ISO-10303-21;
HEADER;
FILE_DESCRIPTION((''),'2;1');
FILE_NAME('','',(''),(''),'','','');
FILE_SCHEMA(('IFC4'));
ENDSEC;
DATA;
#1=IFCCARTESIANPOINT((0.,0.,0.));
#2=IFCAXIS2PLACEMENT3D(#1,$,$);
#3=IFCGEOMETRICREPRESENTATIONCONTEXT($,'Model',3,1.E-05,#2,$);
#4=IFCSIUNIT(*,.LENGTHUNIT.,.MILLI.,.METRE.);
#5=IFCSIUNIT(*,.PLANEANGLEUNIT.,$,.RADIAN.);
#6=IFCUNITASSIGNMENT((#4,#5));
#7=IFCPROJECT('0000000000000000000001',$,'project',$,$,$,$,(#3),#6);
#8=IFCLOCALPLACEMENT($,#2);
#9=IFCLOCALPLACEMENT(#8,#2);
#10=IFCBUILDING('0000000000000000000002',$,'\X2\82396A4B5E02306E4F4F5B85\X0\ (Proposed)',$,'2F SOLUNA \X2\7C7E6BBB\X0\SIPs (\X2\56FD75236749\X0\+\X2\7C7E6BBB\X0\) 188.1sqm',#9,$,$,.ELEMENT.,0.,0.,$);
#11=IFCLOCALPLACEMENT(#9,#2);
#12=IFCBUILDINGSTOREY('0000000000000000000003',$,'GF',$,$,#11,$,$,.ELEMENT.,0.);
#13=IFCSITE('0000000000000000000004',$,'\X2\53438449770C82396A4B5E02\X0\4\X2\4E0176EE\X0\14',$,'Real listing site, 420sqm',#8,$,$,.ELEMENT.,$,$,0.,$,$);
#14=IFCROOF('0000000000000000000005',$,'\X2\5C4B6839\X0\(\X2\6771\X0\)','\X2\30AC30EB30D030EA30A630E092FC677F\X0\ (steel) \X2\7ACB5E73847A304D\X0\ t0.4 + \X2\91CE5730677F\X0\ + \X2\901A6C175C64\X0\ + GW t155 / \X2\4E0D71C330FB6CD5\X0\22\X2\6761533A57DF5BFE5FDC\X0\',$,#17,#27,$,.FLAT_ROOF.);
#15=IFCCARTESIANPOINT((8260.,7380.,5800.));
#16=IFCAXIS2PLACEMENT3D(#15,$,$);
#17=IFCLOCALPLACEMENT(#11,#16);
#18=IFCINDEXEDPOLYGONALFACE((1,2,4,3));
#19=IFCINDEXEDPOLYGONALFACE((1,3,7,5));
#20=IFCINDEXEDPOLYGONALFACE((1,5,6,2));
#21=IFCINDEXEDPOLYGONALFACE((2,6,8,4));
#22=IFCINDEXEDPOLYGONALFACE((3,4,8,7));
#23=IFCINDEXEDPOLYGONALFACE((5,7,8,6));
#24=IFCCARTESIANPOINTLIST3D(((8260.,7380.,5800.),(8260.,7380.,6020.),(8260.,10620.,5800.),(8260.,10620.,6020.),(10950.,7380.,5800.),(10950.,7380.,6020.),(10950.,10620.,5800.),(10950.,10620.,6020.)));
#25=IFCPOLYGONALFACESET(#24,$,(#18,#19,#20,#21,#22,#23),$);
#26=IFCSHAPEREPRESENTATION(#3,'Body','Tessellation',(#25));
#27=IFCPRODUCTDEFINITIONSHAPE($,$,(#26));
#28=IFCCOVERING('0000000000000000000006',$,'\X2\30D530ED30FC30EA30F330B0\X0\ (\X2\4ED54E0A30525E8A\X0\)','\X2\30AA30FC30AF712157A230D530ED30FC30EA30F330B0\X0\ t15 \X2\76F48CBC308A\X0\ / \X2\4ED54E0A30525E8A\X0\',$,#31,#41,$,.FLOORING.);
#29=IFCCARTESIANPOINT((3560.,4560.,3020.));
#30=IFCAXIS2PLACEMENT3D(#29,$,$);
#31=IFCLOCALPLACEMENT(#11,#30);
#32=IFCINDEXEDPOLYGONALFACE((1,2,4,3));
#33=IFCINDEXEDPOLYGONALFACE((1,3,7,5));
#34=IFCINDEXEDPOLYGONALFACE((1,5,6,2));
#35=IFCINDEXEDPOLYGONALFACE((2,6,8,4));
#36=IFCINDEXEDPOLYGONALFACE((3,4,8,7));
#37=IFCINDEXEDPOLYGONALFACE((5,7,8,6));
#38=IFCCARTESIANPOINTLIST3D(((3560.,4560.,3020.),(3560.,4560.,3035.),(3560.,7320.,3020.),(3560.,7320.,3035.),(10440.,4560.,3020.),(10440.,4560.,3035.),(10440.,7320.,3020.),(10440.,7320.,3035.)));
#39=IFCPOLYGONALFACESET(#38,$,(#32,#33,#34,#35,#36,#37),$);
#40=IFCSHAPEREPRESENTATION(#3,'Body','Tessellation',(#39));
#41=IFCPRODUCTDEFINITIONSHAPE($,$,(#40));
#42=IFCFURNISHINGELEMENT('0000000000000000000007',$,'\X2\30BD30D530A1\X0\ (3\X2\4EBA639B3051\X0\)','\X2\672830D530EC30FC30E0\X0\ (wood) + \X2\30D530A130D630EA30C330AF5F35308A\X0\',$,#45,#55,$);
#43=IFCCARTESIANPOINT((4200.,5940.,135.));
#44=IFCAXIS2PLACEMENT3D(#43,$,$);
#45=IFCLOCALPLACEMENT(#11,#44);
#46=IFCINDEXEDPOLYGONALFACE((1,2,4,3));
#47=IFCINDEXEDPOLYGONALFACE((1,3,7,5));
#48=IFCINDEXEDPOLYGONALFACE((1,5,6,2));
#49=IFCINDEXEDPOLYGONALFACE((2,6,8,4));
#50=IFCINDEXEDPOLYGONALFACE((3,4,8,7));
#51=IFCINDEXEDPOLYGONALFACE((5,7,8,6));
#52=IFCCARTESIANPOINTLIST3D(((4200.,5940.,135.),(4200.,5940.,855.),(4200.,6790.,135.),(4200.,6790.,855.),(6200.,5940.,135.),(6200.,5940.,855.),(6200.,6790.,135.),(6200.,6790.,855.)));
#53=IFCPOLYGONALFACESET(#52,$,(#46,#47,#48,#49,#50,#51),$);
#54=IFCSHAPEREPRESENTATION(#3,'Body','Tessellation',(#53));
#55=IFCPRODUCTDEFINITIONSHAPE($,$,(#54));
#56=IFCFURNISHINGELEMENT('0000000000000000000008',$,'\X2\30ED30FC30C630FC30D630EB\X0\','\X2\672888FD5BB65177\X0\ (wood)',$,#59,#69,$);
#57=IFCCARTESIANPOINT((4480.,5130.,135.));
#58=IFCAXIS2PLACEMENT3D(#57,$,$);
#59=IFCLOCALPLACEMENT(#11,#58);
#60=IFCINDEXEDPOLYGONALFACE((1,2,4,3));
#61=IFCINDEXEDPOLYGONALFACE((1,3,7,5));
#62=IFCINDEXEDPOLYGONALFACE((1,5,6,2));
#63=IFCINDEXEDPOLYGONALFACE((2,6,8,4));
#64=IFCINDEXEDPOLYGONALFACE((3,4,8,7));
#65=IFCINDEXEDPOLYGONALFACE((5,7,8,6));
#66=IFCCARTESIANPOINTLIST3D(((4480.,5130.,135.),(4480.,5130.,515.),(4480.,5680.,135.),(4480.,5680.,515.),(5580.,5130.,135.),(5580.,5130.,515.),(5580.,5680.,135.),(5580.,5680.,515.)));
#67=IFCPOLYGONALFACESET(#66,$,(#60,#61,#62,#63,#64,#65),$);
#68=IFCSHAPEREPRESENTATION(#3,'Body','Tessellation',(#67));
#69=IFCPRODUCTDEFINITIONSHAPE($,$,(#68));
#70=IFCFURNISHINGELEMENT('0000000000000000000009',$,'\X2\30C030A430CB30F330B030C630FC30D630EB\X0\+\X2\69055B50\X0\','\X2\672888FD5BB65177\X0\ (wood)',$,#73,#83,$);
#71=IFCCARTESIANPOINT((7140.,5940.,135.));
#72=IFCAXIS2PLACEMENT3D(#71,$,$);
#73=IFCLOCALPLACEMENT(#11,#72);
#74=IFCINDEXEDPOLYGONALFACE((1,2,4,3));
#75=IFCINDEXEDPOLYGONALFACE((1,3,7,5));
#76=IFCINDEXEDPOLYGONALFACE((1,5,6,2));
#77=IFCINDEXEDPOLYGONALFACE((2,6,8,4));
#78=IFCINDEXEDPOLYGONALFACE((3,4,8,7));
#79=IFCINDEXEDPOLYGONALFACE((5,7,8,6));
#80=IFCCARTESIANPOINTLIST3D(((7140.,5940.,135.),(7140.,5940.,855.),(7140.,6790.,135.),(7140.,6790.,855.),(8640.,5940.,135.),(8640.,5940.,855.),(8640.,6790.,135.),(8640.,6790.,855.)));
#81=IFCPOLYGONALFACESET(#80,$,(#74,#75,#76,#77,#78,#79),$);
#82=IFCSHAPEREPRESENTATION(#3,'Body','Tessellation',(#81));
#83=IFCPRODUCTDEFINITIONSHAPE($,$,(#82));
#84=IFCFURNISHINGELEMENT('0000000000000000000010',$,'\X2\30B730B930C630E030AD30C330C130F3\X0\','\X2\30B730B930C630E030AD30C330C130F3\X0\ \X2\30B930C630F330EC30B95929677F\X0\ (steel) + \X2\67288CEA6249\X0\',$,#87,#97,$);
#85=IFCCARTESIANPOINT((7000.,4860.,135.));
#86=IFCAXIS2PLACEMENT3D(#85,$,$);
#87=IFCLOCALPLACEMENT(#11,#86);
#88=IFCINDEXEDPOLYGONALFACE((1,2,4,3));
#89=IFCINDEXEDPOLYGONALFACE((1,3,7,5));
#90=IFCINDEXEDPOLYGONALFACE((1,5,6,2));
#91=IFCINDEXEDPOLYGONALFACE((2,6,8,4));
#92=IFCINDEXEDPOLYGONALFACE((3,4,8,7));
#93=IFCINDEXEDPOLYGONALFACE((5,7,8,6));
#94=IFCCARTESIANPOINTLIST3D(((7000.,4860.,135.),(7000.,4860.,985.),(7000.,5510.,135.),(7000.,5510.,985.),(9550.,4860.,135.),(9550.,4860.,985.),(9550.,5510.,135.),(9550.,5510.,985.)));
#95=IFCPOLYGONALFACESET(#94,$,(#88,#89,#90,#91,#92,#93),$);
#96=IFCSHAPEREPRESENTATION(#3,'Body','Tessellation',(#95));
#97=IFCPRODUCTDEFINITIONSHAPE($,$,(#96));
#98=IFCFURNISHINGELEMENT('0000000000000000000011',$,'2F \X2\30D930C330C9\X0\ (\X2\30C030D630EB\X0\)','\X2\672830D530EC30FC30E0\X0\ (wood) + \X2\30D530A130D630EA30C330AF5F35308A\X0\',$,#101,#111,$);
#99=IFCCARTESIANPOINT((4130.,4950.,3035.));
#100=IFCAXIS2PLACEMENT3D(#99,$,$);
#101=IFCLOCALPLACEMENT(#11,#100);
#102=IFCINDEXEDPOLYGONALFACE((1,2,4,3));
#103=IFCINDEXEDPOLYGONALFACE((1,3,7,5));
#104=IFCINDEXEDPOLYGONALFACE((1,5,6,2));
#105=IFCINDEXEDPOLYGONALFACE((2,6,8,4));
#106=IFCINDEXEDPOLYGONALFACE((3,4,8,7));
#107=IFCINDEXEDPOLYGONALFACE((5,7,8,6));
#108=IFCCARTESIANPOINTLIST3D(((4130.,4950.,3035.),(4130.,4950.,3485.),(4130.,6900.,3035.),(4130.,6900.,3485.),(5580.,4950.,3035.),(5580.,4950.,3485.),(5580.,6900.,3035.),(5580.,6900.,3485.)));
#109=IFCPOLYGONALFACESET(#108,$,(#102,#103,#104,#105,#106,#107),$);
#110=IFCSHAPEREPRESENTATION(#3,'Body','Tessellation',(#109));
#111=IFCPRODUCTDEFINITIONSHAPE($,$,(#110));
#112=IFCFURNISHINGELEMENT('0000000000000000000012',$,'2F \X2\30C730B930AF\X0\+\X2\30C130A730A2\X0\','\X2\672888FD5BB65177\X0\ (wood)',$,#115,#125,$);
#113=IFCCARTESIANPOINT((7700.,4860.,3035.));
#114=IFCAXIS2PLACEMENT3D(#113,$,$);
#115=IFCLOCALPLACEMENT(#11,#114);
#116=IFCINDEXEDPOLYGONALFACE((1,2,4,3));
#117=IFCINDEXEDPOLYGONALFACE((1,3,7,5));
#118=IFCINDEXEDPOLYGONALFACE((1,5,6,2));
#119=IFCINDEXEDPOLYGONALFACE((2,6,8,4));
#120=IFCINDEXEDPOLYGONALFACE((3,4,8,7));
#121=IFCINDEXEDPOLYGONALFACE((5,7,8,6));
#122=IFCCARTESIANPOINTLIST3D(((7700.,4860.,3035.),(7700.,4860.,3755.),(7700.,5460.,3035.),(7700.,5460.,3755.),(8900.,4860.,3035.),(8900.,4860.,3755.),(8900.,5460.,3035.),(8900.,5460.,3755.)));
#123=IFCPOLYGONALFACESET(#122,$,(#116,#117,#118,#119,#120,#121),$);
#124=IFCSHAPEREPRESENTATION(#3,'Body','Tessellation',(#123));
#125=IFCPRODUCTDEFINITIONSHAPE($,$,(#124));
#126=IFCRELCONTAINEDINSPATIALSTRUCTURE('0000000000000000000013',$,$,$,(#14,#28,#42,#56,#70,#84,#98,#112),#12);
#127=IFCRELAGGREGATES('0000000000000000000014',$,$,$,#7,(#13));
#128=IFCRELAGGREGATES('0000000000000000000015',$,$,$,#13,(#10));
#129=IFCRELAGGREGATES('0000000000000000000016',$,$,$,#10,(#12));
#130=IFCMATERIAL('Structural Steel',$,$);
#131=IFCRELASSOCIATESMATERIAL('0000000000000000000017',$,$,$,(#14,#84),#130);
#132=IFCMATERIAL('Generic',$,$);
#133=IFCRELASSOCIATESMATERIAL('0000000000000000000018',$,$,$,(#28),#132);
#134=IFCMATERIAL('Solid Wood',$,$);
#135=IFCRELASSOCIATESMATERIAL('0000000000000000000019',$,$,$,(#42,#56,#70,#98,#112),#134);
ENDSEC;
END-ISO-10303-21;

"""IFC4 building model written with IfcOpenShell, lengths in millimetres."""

from ifc_helpers import new_model, si_unit, frame, frame_2d, origin, place, context, project, spatial, rectangle, extrude, material, element, save


model = new_model("IFC4")

# Units and contexts
model_context = context("Model", 3, precision=1e-05, world=origin())
ifc_project = project(units=[si_unit("LENGTHUNIT", "METRE", prefix="MILLI"), si_unit("PLANEANGLEUNIT", "RADIAN")], contexts=[model_context])

# Site, building, storey
site_placement = place(None, origin())
site = spatial("IfcSite", under=ifc_project, at=site_placement, Name="千葉県船橋市4丁目14", ObjectType="Real listing site, 420sqm", CompositionType="ELEMENT", RefElevation=0.0)
building_placement = place(site_placement, origin())
building = spatial("IfcBuilding", under=site, at=building_placement, Name="船橋市の住宅 (Proposed)", ObjectType="2F SOLUNA 籾殻SIPs (国産杉+籾殻) 188.1sqm", CompositionType="ELEMENT", ElevationOfRefHeight=0.0, ElevationOfTerrain=0.0)
storey_placement = place(building_placement, origin())
storey = spatial("IfcBuildingStorey", under=building, at=storey_placement, Name="GF", CompositionType="ELEMENT", Elevation=0.0)

# Shared definitions
ifc_material_1 = material(Name="Solid Wood")

# Shared definitions
ifc_material_2 = material(Name="Generic")

# Roof
ifc_material_3 = material(Name="Structural Steel")
roof_placement = place(storey_placement, frame((8260.0, 7380.0, 5800.0)))
element("IfcRoof", 1, at=roof_placement, inside=storey, material=ifc_material_3, Name="屋根(東)", Description="ガルバリウム鋼板 (steel) 立平葺き t0.4 + 野地板 + 通気層 + GW t155 / 不燃・法22条区域対応", PredefinedType="FLAT_ROOF", context=model_context, shape_type="SweptSolid", body=[
    extrude(rectangle(XDim=2690.0, YDim=3240.0, at=frame_2d((1345.0, 1620.0))), frame((8260.0, 7380.0, 5800.0)), (0.0, 0.0, 1.0), 220.0),
])

# Covering
covering_placement = place(storey_placement, frame((3560.0, 4560.0, 3020.0)))
element("IfcCovering", 2, at=covering_placement, inside=storey, material=ifc_material_2, Name="フローリング (仕上げ床)", Description="オーク無垢フローリング t15 直貼り / 仕上げ床", PredefinedType="FLOORING", context=model_context, shape_type="SweptSolid", body=[
    extrude(rectangle(XDim=6880.0, YDim=2760.0, at=frame_2d((3440.0, 1380.0))), frame((3560.0, 4560.0, 3020.0)), (0.0, 0.0, 1.0), 15.0),
])

# Furnishing elements
furnishing_1_placement = place(storey_placement, frame((4200.0, 5940.0, 135.0)))
element("IfcFurnishingElement", 3, at=furnishing_1_placement, inside=storey, material=ifc_material_1, Name="ソファ (3人掛け)", Description="木フレーム (wood) + ファブリック張り", context=model_context, shape_type="SweptSolid", body=[
    extrude(rectangle(XDim=2000.0, YDim=850.0, at=frame_2d((1000.0, 425.0))), frame((4200.0, 5940.0, 135.0)), (0.0, 0.0, 1.0), 720.0),
])
furnishing_2_placement = place(storey_placement, frame((4480.0, 5130.0, 135.0)))
element("IfcFurnishingElement", 4, at=furnishing_2_placement, inside=storey, material=ifc_material_1, Name="ローテーブル", Description="木製家具 (wood)", context=model_context, shape_type="SweptSolid", body=[
    extrude(rectangle(XDim=1100.0, YDim=550.0, at=frame_2d((550.0, 275.0))), frame((4480.0, 5130.0, 135.0)), (0.0, 0.0, 1.0), 380.0),
])
furnishing_3_placement = place(storey_placement, frame((7140.0, 5940.0, 135.0)))
element("IfcFurnishingElement", 5, at=furnishing_3_placement, inside=storey, material=ifc_material_1, Name="ダイニングテーブル+椅子", Description="木製家具 (wood)", context=model_context, shape_type="SweptSolid", body=[
    extrude(rectangle(XDim=1500.0, YDim=850.0, at=frame_2d((750.0, 425.0))), frame((7140.0, 5940.0, 135.0)), (0.0, 0.0, 1.0), 720.0),
])
furnishing_4_placement = place(storey_placement, frame((7000.0, 4860.0, 135.0)))
element("IfcFurnishingElement", 6, at=furnishing_4_placement, inside=storey, material=ifc_material_3, Name="システムキッチン", Description="システムキッチン ステンレス天板 (steel) + 木質扉", context=model_context, shape_type="SweptSolid", body=[
    extrude(rectangle(XDim=2550.0, YDim=650.0, at=frame_2d((1275.0, 325.0))), frame((7000.0, 4860.0, 135.0)), (0.0, 0.0, 1.0), 850.0),
])
furnishing_5_placement = place(storey_placement, frame((4130.0, 4950.0, 3035.0)))
element("IfcFurnishingElement", 7, at=furnishing_5_placement, inside=storey, material=ifc_material_1, Name="2F ベッド (ダブル)", Description="木フレーム (wood) + ファブリック張り", context=model_context, shape_type="SweptSolid", body=[
    extrude(rectangle(XDim=1450.0, YDim=1950.0, at=frame_2d((725.0, 975.0))), frame((4130.0, 4950.0, 3035.0)), (0.0, 0.0, 1.0), 450.0),
])
furnishing_6_placement = place(storey_placement, frame((7700.0, 4860.0, 3035.0)))
element("IfcFurnishingElement", 8, at=furnishing_6_placement, inside=storey, material=ifc_material_1, Name="2F デスク+チェア", Description="木製家具 (wood)", context=model_context, shape_type="SweptSolid", body=[
    extrude(rectangle(XDim=1200.0, YDim=600.0, at=frame_2d((600.0, 300.0))), frame((7700.0, 4860.0, 3035.0)), (0.0, 0.0, 1.0), 720.0),
])

save(model, "model.ifc")
